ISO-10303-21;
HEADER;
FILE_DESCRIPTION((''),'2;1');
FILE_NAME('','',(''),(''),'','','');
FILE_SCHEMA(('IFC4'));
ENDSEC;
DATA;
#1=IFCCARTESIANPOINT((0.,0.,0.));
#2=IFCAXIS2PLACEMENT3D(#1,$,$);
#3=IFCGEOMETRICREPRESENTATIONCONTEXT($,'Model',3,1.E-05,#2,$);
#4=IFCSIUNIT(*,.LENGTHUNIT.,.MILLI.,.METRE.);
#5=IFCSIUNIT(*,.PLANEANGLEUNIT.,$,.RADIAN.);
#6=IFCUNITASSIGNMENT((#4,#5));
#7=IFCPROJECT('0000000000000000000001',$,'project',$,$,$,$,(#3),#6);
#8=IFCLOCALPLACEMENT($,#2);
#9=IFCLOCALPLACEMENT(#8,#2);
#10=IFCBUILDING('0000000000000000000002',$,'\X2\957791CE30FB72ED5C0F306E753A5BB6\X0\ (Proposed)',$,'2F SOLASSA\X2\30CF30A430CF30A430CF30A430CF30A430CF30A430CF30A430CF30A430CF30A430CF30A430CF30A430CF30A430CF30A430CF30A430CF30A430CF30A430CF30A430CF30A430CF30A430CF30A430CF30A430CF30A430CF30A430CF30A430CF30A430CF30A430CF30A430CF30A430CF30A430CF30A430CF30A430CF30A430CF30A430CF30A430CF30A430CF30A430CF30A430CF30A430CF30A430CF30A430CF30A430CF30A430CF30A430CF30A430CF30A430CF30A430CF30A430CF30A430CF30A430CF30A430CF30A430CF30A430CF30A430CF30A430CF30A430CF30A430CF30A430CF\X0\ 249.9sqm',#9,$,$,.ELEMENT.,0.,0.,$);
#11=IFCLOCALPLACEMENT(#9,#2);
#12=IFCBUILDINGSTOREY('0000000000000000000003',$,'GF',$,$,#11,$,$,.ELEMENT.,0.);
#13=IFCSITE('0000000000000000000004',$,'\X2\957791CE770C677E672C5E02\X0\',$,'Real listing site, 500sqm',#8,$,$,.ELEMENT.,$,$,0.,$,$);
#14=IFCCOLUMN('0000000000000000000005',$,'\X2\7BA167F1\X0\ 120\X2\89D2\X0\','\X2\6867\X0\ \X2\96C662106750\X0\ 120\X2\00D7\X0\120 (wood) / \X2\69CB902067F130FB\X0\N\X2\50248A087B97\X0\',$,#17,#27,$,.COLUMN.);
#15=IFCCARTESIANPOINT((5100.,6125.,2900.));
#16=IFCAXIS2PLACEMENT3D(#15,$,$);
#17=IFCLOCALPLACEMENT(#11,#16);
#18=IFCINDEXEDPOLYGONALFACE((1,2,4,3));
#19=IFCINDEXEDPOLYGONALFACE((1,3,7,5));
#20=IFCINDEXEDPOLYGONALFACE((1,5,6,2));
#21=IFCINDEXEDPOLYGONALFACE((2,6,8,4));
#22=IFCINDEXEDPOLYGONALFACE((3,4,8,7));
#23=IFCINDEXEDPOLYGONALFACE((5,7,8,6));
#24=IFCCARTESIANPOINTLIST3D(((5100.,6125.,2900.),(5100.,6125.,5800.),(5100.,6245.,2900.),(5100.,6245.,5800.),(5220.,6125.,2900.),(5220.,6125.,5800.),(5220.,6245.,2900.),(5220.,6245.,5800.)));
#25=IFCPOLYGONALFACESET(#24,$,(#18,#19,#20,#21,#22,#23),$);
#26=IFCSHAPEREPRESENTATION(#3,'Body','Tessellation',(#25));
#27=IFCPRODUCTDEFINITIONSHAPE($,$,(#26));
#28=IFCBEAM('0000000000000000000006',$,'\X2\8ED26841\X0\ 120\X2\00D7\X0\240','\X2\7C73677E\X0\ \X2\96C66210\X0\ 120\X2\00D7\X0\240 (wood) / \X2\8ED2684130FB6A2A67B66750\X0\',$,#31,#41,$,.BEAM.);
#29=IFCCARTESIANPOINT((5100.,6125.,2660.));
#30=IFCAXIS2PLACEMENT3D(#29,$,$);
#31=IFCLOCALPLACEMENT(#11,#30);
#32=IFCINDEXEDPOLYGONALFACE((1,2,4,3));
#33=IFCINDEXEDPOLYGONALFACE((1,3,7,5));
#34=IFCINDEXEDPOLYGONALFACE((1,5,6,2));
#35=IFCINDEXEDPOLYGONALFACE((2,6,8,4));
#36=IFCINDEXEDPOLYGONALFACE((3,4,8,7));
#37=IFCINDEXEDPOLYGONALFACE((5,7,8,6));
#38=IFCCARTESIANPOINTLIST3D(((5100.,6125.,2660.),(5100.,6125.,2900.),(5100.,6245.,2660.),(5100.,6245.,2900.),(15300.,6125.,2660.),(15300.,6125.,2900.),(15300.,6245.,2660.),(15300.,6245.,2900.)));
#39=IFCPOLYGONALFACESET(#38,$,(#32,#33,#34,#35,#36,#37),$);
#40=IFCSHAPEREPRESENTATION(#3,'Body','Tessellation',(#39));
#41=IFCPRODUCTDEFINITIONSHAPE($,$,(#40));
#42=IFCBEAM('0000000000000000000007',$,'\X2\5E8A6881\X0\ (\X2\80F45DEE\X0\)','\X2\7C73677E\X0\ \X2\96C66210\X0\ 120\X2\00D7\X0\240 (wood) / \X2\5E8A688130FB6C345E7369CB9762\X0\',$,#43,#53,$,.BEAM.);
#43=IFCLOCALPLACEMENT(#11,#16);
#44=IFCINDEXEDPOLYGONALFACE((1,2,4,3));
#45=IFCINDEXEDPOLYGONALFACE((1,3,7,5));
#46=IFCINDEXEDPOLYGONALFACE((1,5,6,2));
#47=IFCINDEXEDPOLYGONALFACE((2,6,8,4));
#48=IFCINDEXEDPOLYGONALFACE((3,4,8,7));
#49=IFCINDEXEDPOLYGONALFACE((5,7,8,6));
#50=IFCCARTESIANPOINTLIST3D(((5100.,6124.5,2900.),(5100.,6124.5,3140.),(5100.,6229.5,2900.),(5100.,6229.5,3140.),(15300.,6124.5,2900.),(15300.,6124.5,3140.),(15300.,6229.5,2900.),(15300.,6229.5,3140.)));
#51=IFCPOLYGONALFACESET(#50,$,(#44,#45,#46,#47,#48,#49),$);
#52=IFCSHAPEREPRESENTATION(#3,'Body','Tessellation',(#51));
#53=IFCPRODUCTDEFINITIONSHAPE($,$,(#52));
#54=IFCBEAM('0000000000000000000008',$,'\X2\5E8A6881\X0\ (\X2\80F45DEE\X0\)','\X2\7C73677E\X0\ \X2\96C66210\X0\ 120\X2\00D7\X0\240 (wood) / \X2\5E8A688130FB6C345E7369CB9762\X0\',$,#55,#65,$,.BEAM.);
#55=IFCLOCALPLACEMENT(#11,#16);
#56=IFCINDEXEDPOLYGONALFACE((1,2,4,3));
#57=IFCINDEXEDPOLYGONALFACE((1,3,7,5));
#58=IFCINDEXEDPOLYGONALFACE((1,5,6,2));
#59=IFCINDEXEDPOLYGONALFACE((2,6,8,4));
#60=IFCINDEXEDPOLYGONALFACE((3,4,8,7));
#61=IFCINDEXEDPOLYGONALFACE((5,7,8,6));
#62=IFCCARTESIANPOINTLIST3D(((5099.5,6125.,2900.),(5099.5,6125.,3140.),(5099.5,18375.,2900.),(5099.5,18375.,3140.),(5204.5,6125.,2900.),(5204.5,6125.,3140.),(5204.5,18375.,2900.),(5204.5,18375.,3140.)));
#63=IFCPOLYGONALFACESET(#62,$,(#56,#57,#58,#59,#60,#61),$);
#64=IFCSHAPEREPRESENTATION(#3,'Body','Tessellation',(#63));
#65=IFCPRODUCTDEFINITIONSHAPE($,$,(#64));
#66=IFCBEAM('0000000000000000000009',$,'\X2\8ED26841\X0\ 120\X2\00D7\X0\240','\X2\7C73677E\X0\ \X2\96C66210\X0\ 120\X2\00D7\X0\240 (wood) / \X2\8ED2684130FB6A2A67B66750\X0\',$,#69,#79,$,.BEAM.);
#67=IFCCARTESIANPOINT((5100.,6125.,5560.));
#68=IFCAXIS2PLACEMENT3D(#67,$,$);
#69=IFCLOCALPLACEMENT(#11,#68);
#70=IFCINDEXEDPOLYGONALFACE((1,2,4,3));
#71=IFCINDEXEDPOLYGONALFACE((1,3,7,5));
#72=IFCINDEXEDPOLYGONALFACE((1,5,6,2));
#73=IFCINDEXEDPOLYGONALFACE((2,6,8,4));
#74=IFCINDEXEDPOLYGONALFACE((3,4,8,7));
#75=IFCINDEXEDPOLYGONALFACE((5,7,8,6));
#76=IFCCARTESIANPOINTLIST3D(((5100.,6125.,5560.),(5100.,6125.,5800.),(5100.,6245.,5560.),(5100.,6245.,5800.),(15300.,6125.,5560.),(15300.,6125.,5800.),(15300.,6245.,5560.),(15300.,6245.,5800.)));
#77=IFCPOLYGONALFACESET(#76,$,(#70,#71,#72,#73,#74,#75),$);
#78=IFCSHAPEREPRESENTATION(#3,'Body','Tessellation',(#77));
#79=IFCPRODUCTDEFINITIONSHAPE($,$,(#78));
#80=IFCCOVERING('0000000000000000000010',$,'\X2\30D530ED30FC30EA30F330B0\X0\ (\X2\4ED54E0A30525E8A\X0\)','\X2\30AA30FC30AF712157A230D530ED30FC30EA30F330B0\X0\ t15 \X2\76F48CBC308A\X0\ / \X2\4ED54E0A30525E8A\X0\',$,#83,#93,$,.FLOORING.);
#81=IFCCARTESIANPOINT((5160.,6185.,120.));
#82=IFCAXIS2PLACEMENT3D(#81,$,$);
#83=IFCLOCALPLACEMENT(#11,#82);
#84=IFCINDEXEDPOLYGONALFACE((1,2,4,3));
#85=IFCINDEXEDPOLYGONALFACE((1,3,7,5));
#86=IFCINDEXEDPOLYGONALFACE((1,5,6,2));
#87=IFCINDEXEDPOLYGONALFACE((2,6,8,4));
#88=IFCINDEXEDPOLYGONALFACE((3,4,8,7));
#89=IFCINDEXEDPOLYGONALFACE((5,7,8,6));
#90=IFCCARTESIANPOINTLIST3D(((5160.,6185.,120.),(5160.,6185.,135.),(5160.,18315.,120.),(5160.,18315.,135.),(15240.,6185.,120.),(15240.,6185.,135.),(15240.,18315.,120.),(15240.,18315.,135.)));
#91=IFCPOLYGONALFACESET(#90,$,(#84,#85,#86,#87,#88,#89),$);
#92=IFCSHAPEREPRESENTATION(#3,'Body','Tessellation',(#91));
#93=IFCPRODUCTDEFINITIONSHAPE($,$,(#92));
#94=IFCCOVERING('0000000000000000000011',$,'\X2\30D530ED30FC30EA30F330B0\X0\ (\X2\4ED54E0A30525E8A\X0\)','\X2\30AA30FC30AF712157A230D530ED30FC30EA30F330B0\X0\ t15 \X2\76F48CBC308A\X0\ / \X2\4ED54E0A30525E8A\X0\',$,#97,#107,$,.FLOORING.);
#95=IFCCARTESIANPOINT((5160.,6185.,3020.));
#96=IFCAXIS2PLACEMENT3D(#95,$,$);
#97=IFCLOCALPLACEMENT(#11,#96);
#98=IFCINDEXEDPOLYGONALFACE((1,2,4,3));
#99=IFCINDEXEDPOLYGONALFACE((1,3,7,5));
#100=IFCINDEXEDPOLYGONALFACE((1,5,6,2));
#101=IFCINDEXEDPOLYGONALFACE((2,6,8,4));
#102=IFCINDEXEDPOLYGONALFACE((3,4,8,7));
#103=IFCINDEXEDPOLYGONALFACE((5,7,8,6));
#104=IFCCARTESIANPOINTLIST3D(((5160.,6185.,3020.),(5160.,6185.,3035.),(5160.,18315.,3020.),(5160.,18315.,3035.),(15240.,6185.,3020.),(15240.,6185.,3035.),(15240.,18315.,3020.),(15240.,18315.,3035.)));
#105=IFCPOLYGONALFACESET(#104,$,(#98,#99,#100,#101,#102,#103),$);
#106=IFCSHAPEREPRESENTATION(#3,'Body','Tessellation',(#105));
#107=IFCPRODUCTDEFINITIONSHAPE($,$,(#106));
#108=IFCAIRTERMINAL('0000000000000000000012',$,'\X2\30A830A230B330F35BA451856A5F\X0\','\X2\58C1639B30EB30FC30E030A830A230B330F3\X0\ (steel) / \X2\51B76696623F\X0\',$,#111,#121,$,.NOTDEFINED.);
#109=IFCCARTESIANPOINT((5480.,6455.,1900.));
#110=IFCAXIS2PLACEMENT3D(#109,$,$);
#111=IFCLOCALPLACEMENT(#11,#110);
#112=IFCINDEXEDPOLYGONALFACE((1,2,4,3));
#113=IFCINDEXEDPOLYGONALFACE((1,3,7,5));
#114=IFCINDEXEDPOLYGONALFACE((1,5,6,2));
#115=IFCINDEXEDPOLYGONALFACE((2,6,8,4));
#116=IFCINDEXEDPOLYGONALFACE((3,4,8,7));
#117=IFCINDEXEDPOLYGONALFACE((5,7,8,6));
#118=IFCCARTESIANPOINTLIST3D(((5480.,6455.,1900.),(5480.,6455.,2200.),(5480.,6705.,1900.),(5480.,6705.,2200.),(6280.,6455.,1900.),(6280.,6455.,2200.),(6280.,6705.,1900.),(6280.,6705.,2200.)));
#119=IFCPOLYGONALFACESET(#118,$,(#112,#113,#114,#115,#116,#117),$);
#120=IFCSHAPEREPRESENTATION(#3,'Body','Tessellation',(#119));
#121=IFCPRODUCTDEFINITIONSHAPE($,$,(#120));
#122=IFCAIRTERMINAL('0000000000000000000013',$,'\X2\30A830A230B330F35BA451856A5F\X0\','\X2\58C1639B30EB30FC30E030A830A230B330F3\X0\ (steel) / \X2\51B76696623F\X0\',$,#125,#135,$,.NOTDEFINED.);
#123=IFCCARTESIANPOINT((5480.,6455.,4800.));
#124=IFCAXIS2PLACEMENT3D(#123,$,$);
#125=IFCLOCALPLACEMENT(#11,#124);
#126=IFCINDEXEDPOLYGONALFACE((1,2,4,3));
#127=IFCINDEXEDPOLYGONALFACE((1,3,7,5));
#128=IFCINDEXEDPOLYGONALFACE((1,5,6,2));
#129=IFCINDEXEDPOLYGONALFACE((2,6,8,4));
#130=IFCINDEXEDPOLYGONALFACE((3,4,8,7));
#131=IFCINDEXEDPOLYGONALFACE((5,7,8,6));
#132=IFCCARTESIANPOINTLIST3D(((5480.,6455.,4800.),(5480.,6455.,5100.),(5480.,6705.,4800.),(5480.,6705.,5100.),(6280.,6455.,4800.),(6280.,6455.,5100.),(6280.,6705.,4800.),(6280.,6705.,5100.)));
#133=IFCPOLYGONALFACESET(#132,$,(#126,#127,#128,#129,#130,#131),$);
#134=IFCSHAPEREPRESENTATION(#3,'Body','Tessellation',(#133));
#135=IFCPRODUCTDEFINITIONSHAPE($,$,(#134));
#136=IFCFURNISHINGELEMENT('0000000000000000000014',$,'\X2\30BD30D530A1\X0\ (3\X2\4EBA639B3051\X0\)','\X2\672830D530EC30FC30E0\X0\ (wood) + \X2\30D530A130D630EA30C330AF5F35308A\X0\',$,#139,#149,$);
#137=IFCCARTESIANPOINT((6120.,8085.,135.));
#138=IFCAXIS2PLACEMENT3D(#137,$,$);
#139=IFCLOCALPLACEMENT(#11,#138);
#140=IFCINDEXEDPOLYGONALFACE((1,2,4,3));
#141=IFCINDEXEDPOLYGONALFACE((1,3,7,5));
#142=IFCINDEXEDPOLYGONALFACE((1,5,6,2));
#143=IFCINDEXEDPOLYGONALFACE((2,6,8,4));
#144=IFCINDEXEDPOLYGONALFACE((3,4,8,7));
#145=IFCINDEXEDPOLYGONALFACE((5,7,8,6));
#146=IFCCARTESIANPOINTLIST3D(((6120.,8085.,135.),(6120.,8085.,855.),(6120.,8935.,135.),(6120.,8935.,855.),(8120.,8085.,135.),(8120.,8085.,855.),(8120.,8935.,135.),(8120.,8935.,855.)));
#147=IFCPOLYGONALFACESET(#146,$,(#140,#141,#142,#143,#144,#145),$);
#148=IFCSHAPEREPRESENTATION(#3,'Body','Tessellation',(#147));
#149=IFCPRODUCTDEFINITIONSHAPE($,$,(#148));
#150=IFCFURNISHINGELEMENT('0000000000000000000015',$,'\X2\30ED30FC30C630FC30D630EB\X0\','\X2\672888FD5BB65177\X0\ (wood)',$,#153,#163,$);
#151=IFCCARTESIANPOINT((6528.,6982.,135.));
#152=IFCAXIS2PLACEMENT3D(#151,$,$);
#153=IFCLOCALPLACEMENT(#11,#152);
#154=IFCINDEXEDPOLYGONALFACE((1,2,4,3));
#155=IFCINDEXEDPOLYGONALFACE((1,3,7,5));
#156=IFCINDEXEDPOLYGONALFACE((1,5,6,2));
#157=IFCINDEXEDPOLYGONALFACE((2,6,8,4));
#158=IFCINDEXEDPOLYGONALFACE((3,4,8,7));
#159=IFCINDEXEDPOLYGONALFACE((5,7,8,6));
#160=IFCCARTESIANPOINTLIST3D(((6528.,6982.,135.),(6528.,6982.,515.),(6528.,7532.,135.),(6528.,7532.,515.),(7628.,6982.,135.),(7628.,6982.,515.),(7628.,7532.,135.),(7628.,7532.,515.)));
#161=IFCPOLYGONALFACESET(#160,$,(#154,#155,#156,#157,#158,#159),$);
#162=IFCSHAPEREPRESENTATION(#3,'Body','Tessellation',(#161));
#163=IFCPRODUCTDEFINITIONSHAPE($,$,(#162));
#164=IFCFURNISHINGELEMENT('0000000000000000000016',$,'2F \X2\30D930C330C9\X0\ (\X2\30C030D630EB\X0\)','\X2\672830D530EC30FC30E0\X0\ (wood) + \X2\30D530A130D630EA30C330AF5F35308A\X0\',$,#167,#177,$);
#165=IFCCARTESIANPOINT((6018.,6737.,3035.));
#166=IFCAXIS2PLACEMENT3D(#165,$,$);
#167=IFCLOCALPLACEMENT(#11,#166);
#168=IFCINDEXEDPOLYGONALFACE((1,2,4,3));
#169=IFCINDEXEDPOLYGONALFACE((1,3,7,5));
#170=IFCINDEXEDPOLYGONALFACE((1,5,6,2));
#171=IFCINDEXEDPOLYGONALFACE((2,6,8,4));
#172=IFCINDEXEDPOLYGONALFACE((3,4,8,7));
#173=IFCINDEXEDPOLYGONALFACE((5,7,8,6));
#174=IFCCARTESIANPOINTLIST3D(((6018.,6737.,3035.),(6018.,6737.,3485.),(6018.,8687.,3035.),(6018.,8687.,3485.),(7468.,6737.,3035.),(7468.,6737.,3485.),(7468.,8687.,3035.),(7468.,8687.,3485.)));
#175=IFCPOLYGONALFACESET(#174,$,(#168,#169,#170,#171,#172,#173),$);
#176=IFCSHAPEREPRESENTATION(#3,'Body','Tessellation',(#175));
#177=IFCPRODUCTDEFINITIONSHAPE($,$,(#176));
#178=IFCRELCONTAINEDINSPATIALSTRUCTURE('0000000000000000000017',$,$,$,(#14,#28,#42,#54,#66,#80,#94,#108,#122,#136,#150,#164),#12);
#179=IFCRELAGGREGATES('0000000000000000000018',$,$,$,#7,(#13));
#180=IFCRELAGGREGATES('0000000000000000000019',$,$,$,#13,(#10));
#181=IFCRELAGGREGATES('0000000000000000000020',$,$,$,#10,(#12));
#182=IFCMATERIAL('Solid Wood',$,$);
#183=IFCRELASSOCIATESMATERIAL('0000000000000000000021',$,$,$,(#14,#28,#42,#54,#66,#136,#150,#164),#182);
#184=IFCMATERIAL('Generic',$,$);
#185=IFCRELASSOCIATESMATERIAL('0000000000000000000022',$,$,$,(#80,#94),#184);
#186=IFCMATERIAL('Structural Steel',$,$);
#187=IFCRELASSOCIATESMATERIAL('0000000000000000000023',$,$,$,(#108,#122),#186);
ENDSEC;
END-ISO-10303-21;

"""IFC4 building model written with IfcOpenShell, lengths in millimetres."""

from ifc_helpers import new_model, si_unit, frame, frame_2d, origin, place, context, project, spatial, rectangle, extrude, material, element, save


model = new_model("IFC4")

# Units and contexts
model_context = context("Model", 3, precision=1e-05, world=origin())
ifc_project = project(units=[si_unit("LENGTHUNIT", "METRE", prefix="MILLI"), si_unit("PLANEANGLEUNIT", "RADIAN")], contexts=[model_context])

# Site, building, storey
site_placement = place(None, origin())
site = spatial("IfcSite", under=ifc_project, at=site_placement, Name="長野県松本市", ObjectType="Real listing site, 500sqm", CompositionType="ELEMENT", RefElevation=0.0)
building_placement = place(site_placement, origin())
building = spatial("IfcBuilding", under=site, at=building_placement, Name="長野・狭小の町家 (Proposed)", ObjectType="2F SOLASSAハイハイハイハイハイハイハイハイハイハイハイハイハイハイハイハイハイハイハイハイハイハイハイハイハイハイハイハイハイハイハイハイハイハイハイハイハイハイハイハイハイハイハイハイハイハイハイハイハイハイハイハイハイハイハイハイハ 249.9sqm", CompositionType="ELEMENT", ElevationOfRefHeight=0.0, ElevationOfTerrain=0.0)
storey_placement = place(building_placement, origin())
storey = spatial("IfcBuildingStorey", under=building, at=storey_placement, Name="GF", CompositionType="ELEMENT", Elevation=0.0)

# Column
ifc_material_1 = material(Name="Solid Wood")
column_1_placement = place(storey_placement, frame((5100.0, 6125.0, 2900.0)))
element("IfcColumn", 1, at=column_1_placement, inside=storey, material=ifc_material_1, Name="管柱 120角", Description="桧 集成材 120×120 (wood) / 構造柱・N値計算", PredefinedType="COLUMN", context=model_context, shape_type="SweptSolid", body=[
    extrude(rectangle(XDim=120.0, YDim=120.0, at=frame_2d((60.0, 60.0))), frame((5100.0, 6125.0, 2900.0)), (0.0, 0.0, 1.0), 2900.0),
])

# Beams
beam_1_placement = place(storey_placement, frame((5100.0, 6125.0, 2660.0)))
element("IfcBeam", 2, at=beam_1_placement, inside=storey, material=ifc_material_1, Name="軒桁 120×240", Description="米松 集成 120×240 (wood) / 軒桁・横架材", PredefinedType="BEAM", context=model_context, shape_type="SweptSolid", body=[
    extrude(rectangle(XDim=10200.0, YDim=120.0, at=frame_2d((5100.0, 60.0))), frame((5100.0, 6125.0, 2660.0)), (0.0, 0.0, 1.0), 240.0),
])
beam_2_placement = place(storey_placement, frame((5100.0, 6125.0, 2900.0)))
element("IfcBeam", 3, at=beam_2_placement, inside=storey, material=ifc_material_1, Name="床梁 (胴差)", Description="米松 集成 120×240 (wood) / 床梁・水平構面", PredefinedType="BEAM", context=model_context, shape_type="SweptSolid", body=[
    extrude(rectangle(XDim=10200.0, YDim=105.0, at=frame_2d((5100.0, 52.0))), frame((5100.0, 6125.0, 2900.0)), (0.0, 0.0, 1.0), 240.0),
])
beam_3_placement = place(storey_placement, frame((5100.0, 6125.0, 2900.0)))
element("IfcBeam", 4, at=beam_3_placement, inside=storey, material=ifc_material_1, Name="床梁 (胴差)", Description="米松 集成 120×240 (wood) / 床梁・水平構面", PredefinedType="BEAM", context=model_context, shape_type="SweptSolid", body=[
    extrude(rectangle(XDim=105.0, YDim=12250.0, at=frame_2d((52.0, 6125.0))), frame((5100.0, 6125.0, 2900.0)), (0.0, 0.0, 1.0), 240.0),
])
beam_4_placement = place(storey_placement, frame((5100.0, 6125.0, 5560.0)))
element("IfcBeam", 5, at=beam_4_placement, inside=storey, material=ifc_material_1, Name="軒桁 120×240", Description="米松 集成 120×240 (wood) / 軒桁・横架材", PredefinedType="BEAM", context=model_context, shape_type="SweptSolid", body=[
    extrude(rectangle(XDim=10200.0, YDim=120.0, at=frame_2d((5100.0, 60.0))), frame((5100.0, 6125.0, 5560.0)), (0.0, 0.0, 1.0), 240.0),
])

# Coverings
ifc_material_2 = material(Name="Generic")
covering_1_placement = place(storey_placement, frame((5160.0, 6185.0, 120.0)))
element("IfcCovering", 6, at=covering_1_placement, inside=storey, material=ifc_material_2, Name="フローリング (仕上げ床)", Description="オーク無垢フローリング t15 直貼り / 仕上げ床", PredefinedType="FLOORING", context=model_context, shape_type="SweptSolid", body=[
    extrude(rectangle(XDim=10080.0, YDim=12130.0, at=frame_2d((5040.0, 6065.0))), frame((5160.0, 6185.0, 120.0)), (0.0, 0.0, 1.0), 15.0),
])
covering_2_placement = place(storey_placement, frame((5160.0, 6185.0, 3020.0)))
element("IfcCovering", 7, at=covering_2_placement, inside=storey, material=ifc_material_2, Name="フローリング (仕上げ床)", Description="オーク無垢フローリング t15 直貼り / 仕上げ床", PredefinedType="FLOORING", context=model_context, shape_type="SweptSolid", body=[
    extrude(rectangle(XDim=10080.0, YDim=12130.0, at=frame_2d((5040.0, 6065.0))), frame((5160.0, 6185.0, 3020.0)), (0.0, 0.0, 1.0), 15.0),
])

# Air terminals
ifc_material_3 = material(Name="Structural Steel")
air_terminal_1_placement = place(storey_placement, frame((5480.0, 6455.0, 1900.0)))
element("IfcAirTerminal", 8, at=air_terminal_1_placement, inside=storey, material=ifc_material_3, Name="エアコン室内機", Description="壁掛ルームエアコン (steel) / 冷暖房", PredefinedType="NOTDEFINED", context=model_context, shape_type="SweptSolid", body=[
    extrude(rectangle(XDim=800.0, YDim=250.0, at=frame_2d((400.0, 125.0))), frame((5480.0, 6455.0, 1900.0)), (0.0, 0.0, 1.0), 300.0),
])
air_terminal_2_placement = place(storey_placement, frame((5480.0, 6455.0, 4800.0)))
element("IfcAirTerminal", 9, at=air_terminal_2_placement, inside=storey, material=ifc_material_3, Name="エアコン室内機", Description="壁掛ルームエアコン (steel) / 冷暖房", PredefinedType="NOTDEFINED", context=model_context, shape_type="SweptSolid", body=[
    extrude(rectangle(XDim=800.0, YDim=250.0, at=frame_2d((400.0, 125.0))), frame((5480.0, 6455.0, 4800.0)), (0.0, 0.0, 1.0), 300.0),
])

# Furnishing elements
furnishing_1_placement = place(storey_placement, frame((6120.0, 8085.0, 135.0)))
element("IfcFurnishingElement", 10, at=furnishing_1_placement, inside=storey, material=ifc_material_1, Name="ソファ (3人掛け)", Description="木フレーム (wood) + ファブリック張り", context=model_context, shape_type="SweptSolid", body=[
    extrude(rectangle(XDim=2000.0, YDim=850.0, at=frame_2d((1000.0, 425.0))), frame((6120.0, 8085.0, 135.0)), (0.0, 0.0, 1.0), 720.0),
])
furnishing_2_placement = place(storey_placement, frame((6528.0, 6982.0, 135.0)))
element("IfcFurnishingElement", 11, at=furnishing_2_placement, inside=storey, material=ifc_material_1, Name="ローテーブル", Description="木製家具 (wood)", context=model_context, shape_type="SweptSolid", body=[
    extrude(rectangle(XDim=1100.0, YDim=550.0, at=frame_2d((550.0, 275.0))), frame((6528.0, 6982.0, 135.0)), (0.0, 0.0, 1.0), 380.0),
])
furnishing_3_placement = place(storey_placement, frame((6018.0, 6737.0, 3035.0)))
element("IfcFurnishingElement", 12, at=furnishing_3_placement, inside=storey, material=ifc_material_1, Name="2F ベッド (ダブル)", Description="木フレーム (wood) + ファブリック張り", context=model_context, shape_type="SweptSolid", body=[
    extrude(rectangle(XDim=1450.0, YDim=1950.0, at=frame_2d((725.0, 975.0))), frame((6018.0, 6737.0, 3035.0)), (0.0, 0.0, 1.0), 450.0),
])

save(model, "model.ifc")
